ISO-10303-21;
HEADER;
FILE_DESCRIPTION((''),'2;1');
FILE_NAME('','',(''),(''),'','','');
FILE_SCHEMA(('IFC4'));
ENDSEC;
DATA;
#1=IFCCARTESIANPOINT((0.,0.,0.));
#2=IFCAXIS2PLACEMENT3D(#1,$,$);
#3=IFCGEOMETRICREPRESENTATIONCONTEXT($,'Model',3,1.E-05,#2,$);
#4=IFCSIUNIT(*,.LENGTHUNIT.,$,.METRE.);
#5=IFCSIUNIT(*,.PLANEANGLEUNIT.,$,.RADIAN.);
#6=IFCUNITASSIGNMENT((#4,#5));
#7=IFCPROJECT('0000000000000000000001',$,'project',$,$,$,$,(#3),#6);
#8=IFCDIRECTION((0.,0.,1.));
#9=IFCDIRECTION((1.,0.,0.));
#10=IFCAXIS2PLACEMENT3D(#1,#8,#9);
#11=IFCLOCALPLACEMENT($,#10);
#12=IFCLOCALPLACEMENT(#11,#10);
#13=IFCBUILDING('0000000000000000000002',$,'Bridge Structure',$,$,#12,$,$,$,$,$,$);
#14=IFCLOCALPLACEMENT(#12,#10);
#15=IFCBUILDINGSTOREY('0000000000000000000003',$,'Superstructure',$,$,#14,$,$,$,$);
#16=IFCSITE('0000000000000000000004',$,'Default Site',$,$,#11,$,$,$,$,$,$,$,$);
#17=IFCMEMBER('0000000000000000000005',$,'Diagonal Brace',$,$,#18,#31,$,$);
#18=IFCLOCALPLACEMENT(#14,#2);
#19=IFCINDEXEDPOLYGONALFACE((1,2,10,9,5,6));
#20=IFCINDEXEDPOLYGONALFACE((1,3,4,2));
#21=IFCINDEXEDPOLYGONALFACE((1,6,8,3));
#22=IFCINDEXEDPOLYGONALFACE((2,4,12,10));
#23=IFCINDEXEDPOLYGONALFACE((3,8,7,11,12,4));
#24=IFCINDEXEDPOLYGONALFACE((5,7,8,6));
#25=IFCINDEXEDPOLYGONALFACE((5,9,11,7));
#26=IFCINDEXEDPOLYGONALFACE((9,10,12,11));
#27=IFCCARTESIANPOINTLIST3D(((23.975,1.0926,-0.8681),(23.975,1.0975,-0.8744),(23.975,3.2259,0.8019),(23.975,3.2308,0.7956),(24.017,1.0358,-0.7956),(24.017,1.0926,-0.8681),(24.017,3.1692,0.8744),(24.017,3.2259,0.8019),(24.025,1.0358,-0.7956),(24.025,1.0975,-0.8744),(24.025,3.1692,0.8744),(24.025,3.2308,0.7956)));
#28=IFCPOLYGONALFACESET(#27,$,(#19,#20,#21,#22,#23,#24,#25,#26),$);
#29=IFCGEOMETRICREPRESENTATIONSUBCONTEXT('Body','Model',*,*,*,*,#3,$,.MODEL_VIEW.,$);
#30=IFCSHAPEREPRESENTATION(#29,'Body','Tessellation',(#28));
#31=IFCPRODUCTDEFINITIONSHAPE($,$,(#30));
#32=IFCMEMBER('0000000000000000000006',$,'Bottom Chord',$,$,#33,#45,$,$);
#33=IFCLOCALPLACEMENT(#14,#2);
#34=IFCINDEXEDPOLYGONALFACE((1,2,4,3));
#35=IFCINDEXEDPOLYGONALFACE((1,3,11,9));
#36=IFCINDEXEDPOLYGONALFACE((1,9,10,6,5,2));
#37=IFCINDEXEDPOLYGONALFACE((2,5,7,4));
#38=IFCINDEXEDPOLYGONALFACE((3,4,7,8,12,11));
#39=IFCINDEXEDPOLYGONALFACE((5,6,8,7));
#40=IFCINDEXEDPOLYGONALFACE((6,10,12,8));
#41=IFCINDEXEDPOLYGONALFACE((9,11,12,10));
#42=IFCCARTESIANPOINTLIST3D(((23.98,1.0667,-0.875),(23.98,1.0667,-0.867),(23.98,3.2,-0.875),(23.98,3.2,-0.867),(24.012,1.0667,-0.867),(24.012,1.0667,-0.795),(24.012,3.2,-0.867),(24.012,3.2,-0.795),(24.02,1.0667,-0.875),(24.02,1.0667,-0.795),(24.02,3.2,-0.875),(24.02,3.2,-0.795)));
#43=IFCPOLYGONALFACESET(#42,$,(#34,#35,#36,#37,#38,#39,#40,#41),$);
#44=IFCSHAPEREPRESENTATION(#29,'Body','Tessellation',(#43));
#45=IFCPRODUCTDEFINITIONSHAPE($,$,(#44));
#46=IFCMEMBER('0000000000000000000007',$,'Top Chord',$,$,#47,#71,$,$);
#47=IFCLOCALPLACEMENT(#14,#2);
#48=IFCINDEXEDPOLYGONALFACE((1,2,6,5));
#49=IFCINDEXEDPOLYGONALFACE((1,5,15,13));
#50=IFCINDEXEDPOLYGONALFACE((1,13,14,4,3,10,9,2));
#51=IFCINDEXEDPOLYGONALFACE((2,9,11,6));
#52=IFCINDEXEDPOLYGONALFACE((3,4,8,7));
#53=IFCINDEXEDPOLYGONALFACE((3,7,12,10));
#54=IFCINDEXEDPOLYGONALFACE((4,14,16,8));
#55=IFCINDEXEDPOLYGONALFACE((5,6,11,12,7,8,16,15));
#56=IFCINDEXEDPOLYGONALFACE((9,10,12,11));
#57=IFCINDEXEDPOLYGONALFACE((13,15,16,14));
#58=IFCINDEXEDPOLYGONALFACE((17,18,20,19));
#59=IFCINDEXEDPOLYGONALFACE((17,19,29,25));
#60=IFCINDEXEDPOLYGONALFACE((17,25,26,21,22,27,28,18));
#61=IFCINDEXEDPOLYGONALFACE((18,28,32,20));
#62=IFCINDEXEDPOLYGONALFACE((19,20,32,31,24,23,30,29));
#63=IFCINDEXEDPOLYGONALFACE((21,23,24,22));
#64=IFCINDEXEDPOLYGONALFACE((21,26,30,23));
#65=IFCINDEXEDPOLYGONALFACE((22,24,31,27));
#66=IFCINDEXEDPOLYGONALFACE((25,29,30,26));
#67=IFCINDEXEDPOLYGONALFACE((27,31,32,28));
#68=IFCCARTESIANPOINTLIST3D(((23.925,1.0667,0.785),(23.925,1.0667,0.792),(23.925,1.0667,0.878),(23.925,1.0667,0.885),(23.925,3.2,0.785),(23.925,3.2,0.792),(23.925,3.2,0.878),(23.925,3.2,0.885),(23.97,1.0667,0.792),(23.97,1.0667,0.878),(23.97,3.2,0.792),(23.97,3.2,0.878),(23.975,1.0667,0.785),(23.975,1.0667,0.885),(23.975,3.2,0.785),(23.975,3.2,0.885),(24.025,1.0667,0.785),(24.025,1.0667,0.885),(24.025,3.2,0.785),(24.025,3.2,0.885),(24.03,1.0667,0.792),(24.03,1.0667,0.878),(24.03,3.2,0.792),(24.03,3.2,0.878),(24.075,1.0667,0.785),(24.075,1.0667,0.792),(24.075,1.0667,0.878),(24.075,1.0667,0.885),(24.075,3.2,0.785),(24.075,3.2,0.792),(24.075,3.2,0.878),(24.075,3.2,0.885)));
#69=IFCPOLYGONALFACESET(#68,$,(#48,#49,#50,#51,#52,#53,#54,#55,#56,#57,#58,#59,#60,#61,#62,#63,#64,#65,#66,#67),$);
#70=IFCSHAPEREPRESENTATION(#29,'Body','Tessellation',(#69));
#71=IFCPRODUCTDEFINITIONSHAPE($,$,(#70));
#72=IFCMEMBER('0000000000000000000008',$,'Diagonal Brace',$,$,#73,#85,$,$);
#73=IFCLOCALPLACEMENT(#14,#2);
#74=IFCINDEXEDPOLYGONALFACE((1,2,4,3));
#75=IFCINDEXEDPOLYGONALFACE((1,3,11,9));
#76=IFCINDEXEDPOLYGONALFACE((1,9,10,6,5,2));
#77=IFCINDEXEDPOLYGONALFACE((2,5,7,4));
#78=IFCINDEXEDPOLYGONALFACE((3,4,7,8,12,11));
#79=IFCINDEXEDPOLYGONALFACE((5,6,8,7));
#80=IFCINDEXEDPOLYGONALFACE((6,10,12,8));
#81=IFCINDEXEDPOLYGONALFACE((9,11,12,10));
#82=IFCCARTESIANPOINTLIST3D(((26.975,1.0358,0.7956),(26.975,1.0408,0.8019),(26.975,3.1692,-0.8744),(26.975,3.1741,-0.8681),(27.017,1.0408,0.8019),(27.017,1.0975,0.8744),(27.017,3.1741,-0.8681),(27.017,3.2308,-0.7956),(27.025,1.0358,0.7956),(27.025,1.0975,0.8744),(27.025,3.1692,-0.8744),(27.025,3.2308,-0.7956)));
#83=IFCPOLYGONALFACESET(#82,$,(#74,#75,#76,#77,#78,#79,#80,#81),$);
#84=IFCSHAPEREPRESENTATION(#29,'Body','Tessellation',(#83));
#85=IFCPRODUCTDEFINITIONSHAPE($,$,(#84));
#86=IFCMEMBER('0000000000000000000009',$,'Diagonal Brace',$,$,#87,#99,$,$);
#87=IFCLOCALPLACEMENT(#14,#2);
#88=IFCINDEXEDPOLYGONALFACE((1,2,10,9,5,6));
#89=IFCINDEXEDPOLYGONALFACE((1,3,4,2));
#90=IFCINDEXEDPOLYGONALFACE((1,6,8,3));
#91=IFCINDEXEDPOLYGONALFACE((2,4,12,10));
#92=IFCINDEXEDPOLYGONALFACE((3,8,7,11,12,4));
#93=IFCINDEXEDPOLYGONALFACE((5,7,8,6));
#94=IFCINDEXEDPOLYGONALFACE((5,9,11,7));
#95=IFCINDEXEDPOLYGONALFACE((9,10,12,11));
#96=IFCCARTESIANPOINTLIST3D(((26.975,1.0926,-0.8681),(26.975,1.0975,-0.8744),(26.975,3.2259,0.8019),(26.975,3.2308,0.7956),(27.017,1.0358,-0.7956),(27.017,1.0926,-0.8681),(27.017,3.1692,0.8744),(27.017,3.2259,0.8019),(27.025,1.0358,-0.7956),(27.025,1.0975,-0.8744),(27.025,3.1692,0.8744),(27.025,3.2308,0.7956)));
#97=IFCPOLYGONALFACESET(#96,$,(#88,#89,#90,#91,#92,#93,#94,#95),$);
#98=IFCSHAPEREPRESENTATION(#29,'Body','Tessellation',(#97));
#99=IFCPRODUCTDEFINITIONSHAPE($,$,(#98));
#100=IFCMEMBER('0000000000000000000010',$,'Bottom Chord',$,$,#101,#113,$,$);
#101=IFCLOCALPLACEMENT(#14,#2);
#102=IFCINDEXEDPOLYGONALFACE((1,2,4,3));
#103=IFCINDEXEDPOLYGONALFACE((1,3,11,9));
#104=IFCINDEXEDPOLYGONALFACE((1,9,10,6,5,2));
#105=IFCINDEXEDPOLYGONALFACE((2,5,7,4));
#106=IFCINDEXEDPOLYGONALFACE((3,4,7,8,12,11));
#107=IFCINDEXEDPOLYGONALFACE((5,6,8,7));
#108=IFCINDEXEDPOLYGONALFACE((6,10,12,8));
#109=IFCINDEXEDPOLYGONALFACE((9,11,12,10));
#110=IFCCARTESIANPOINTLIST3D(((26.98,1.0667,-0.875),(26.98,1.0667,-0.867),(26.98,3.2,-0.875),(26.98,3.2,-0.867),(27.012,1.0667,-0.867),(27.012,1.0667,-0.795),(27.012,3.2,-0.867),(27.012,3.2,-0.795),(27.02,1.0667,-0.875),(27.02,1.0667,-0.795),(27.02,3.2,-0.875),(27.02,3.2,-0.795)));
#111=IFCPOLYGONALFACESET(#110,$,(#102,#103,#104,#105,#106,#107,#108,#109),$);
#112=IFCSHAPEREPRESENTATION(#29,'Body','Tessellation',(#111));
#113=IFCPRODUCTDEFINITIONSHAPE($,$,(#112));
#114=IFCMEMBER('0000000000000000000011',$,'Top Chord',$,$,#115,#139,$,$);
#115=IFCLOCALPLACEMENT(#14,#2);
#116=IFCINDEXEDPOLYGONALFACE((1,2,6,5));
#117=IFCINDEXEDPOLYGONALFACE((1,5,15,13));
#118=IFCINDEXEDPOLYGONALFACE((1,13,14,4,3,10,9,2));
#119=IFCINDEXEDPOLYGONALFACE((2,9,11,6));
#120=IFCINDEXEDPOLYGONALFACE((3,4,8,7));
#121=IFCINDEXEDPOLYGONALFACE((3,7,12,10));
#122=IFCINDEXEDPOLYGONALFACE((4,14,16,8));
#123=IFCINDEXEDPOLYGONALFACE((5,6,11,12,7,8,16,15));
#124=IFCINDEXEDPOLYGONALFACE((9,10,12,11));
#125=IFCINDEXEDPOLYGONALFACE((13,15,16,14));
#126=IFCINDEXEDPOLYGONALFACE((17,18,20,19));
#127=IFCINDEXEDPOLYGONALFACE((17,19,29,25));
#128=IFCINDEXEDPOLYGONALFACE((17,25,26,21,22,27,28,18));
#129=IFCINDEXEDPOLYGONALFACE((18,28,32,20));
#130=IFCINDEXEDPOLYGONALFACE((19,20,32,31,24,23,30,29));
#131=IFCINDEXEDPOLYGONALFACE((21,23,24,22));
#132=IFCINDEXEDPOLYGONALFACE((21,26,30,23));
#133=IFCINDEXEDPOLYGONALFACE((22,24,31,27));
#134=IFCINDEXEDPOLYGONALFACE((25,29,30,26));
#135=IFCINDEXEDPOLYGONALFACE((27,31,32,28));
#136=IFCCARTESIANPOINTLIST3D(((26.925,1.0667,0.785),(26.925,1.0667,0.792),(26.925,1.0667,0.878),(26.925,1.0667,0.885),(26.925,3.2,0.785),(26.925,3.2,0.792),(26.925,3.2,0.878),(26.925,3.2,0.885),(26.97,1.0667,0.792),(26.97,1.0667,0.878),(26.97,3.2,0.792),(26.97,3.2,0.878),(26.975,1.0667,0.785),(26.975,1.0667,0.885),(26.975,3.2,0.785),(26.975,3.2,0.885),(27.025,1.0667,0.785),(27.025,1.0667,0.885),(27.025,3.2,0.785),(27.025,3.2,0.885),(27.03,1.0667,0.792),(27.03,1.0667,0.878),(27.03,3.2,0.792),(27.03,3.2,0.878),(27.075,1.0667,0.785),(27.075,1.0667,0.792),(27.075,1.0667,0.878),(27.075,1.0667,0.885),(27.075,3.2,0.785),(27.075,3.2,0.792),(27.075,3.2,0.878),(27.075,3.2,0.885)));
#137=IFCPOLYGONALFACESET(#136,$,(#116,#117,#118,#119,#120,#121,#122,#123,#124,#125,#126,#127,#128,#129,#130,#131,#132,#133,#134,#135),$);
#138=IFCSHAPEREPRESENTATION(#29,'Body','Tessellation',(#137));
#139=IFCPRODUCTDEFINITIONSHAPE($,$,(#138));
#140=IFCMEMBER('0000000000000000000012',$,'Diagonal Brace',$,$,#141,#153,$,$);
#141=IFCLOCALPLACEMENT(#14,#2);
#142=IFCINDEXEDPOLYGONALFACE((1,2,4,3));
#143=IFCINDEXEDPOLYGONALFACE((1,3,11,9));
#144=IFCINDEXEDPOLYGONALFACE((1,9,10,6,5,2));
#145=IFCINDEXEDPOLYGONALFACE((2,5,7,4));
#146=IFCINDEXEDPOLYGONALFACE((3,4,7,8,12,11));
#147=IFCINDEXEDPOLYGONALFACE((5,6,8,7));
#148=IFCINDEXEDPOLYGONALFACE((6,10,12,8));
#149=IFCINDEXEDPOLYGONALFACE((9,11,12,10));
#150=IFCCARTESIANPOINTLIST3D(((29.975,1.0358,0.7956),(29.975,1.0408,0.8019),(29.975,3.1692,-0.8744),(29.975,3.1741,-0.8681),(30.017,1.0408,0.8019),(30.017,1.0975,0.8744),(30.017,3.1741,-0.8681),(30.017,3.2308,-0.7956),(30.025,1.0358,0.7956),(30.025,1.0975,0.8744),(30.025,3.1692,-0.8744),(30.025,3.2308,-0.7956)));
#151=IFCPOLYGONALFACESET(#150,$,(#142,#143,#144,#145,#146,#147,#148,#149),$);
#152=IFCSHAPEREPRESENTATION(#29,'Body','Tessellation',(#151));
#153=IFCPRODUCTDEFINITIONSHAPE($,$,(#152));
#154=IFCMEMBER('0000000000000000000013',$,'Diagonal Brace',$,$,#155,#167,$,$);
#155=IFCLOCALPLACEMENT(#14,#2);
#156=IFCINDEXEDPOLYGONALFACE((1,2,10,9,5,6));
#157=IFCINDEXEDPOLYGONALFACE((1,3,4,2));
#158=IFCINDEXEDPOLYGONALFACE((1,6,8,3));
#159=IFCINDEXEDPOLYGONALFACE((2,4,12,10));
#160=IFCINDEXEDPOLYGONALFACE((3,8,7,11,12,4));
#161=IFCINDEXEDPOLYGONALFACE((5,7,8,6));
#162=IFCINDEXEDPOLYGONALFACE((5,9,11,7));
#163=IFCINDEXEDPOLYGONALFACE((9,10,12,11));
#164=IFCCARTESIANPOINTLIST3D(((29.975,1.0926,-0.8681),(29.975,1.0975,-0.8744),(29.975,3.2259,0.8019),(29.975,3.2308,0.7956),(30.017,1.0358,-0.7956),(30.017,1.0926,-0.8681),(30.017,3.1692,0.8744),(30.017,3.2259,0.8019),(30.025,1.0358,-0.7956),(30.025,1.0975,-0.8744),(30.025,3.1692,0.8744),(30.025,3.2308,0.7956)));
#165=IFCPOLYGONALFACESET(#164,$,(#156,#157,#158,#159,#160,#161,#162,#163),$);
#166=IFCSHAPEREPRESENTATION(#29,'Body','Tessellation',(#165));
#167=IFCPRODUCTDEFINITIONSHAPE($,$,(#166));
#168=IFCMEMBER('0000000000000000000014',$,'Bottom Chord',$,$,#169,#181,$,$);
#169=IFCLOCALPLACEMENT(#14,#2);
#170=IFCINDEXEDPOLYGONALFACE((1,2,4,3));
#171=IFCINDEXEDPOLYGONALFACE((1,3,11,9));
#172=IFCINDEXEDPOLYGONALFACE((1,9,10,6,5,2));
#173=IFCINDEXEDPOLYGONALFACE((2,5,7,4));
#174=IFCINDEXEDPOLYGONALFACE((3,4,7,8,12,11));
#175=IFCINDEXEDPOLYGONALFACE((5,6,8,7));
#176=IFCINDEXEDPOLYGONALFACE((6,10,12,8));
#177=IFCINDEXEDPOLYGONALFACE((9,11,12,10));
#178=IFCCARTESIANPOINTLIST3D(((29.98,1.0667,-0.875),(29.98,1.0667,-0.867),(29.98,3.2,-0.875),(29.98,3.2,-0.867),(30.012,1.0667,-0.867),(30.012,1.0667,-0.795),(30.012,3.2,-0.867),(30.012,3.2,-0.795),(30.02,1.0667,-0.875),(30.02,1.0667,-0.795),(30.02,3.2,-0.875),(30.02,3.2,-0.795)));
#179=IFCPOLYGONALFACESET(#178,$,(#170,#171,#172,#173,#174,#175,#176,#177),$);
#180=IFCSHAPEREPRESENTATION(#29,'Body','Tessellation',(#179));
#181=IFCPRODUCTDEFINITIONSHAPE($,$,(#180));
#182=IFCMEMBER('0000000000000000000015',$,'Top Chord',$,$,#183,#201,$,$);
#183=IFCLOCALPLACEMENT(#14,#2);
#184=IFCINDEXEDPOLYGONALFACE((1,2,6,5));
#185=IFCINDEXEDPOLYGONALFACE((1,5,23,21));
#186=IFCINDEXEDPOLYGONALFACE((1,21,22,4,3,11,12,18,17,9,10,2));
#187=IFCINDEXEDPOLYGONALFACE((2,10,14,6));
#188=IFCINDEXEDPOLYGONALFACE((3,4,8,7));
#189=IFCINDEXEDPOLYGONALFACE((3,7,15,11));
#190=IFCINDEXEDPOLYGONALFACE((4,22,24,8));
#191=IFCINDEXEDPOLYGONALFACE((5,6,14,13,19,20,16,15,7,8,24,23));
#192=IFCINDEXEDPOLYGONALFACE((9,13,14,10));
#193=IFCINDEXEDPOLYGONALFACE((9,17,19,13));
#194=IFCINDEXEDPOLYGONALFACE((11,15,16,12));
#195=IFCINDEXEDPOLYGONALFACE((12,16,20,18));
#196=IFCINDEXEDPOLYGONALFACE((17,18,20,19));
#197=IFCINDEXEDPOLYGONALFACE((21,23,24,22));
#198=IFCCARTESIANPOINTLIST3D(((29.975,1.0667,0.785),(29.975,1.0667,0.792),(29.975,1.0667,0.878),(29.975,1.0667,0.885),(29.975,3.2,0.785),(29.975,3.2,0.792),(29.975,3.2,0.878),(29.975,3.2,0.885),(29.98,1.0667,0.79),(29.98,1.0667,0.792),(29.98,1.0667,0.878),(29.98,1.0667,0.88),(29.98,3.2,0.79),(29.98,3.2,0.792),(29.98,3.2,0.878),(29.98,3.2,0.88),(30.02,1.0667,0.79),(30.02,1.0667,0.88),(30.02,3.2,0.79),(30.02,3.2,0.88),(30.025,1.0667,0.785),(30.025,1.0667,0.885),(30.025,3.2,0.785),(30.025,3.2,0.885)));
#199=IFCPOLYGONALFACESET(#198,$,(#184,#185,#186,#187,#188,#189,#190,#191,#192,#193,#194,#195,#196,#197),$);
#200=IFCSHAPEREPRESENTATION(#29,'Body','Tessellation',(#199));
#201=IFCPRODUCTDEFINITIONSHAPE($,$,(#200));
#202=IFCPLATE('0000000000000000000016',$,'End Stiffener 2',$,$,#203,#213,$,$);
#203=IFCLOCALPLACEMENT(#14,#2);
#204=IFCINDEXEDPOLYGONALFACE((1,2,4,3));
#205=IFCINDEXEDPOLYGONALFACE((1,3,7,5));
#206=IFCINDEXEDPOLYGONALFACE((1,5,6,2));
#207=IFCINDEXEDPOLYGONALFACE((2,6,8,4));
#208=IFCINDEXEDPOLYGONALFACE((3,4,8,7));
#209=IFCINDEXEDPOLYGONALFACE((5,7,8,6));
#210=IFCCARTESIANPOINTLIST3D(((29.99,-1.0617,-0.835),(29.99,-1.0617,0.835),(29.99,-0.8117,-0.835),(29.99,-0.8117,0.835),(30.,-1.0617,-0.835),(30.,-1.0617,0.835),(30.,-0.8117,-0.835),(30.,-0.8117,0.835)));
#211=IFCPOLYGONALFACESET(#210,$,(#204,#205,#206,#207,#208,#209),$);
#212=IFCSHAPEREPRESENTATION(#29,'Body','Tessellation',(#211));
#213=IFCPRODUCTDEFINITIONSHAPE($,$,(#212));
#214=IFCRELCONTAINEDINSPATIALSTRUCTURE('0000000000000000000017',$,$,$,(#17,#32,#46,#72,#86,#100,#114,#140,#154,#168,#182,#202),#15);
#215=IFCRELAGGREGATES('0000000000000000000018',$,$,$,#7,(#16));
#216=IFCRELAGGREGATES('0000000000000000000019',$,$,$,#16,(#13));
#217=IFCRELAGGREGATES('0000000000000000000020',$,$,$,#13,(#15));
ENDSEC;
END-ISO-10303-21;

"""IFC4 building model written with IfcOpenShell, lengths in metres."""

from ifc_helpers import new_model, si_unit, frame, origin, origin_with_axes, origin_2d_with_axis, place, context, subcontext, project, spatial, polyline, rectangle, l_section, c_section, outline, composite_profile, extrude, element, save


model = new_model("IFC4")

# Units and contexts
model_context = context("Model", 3, precision=1e-05, world=origin())
body_context = subcontext(model_context, "Body", "Model", "MODEL_VIEW")
ifc_project = project(units=[si_unit("LENGTHUNIT", "METRE"), si_unit("PLANEANGLEUNIT", "RADIAN")], contexts=[model_context])

# Site, building, storey
site_placement = place(None, origin_with_axes())
site = spatial("IfcSite", under=ifc_project, at=site_placement, Name="Default Site")
building_placement = place(site_placement, origin_with_axes())
building = spatial("IfcBuilding", under=site, at=building_placement, Name="Bridge Structure")
storey_placement = place(building_placement, origin_with_axes())
storey = spatial("IfcBuildingStorey", under=building, at=storey_placement, Name="Superstructure")

# Members
member_1_placement = place(storey_placement, frame((24.0, 1.0667, -0.835), z_axis=(0.0, 0.787427, 0.616408), x_axis=(-1.0, 0.0, 0.0)))
element("IfcMember", 1, at=member_1_placement, inside=storey, Name="Diagonal Brace", context=body_context, shape_type="SweptSolid", body=[
    extrude(l_section(Depth=0.1, Width=0.05, Thickness=0.008, at=origin_2d_with_axis()), origin_with_axes(), (0.0, 0.0, 1.0), 2.7092),
])
member_2_placement = place(storey_placement, frame((24.0, 1.0667, -0.835), z_axis=(0.0, 1.0, 0.0), x_axis=(-1.0, 0.0, 0.0)))
element("IfcMember", 2, at=member_2_placement, inside=storey, Name="Bottom Chord", context=body_context, shape_type="SweptSolid", body=[
    extrude(l_section(Depth=0.08, Width=0.04, Thickness=0.008, at=origin_2d_with_axis()), origin_with_axes(), (0.0, 0.0, 1.0), 2.1333),
])
member_3_placement = place(storey_placement, frame((24.0, 1.0667, 0.835), z_axis=(0.0, 1.0, 0.0), x_axis=(-1.0, 0.0, 0.0)))
element("IfcMember", 3, at=member_3_placement, inside=storey, Name="Top Chord", context=body_context, shape_type="SweptSolid", body=[
    extrude(composite_profile([outline(polyline([(-0.025, -0.05), (-0.025, 0.05), (-0.075, 0.05), (-0.075, 0.043), (-0.03, 0.043), (-0.03, -0.043), (-0.075, -0.043), (-0.075, -0.05), (-0.025, -0.05)])), outline(polyline([(0.025, -0.05), (0.075, -0.05), (0.075, -0.043), (0.03, -0.043), (0.03, 0.043), (0.075, 0.043), (0.075, 0.05), (0.025, 0.05), (0.025, -0.05)]))]), origin_with_axes(), (0.0, 0.0, 1.0), 2.1333),
])
for number, where, z_axis, x_axis, name in (
    (4, (27.0, 1.0667, 0.835), (0.0, 0.787427, -0.616408), (-1.0, 0.0, 0.0), "Diagonal Brace"),
    (5, (27.0, 1.0667, -0.835), (0.0, 0.787427, 0.616408), (-1.0, 0.0, 0.0), "Diagonal Brace"),
):
    element("IfcMember", number, at=place(storey_placement, frame(where, z_axis=z_axis, x_axis=x_axis)), inside=storey, Name=name, context=body_context, shape_type="SweptSolid", body=[
        extrude(l_section(Depth=0.1, Width=0.05, Thickness=0.008, at=origin_2d_with_axis()), origin_with_axes(), (0.0, 0.0, 1.0), 2.7092),
    ])
member_4_placement = place(storey_placement, frame((27.0, 1.0667, -0.835), z_axis=(0.0, 1.0, 0.0), x_axis=(-1.0, 0.0, 0.0)))
element("IfcMember", 6, at=member_4_placement, inside=storey, Name="Bottom Chord", context=body_context, shape_type="SweptSolid", body=[
    extrude(l_section(Depth=0.08, Width=0.04, Thickness=0.008, at=origin_2d_with_axis()), origin_with_axes(), (0.0, 0.0, 1.0), 2.1333),
])
member_5_placement = place(storey_placement, frame((27.0, 1.0667, 0.835), z_axis=(0.0, 1.0, 0.0), x_axis=(-1.0, 0.0, 0.0)))
element("IfcMember", 7, at=member_5_placement, inside=storey, Name="Top Chord", context=body_context, shape_type="SweptSolid", body=[
    extrude(composite_profile([outline(polyline([(-0.025, -0.05), (-0.025, 0.05), (-0.075, 0.05), (-0.075, 0.043), (-0.03, 0.043), (-0.03, -0.043), (-0.075, -0.043), (-0.075, -0.05), (-0.025, -0.05)])), outline(polyline([(0.025, -0.05), (0.075, -0.05), (0.075, -0.043), (0.03, -0.043), (0.03, 0.043), (0.075, 0.043), (0.075, 0.05), (0.025, 0.05), (0.025, -0.05)]))]), origin_with_axes(), (0.0, 0.0, 1.0), 2.1333),
])
for number, where, z_axis, x_axis, name in (
    (8, (30.0, 1.0667, 0.835), (0.0, 0.787427, -0.616408), (-1.0, 0.0, 0.0), "Diagonal Brace"),
    (9, (30.0, 1.0667, -0.835), (0.0, 0.787427, 0.616408), (-1.0, 0.0, 0.0), "Diagonal Brace"),
):
    element("IfcMember", number, at=place(storey_placement, frame(where, z_axis=z_axis, x_axis=x_axis)), inside=storey, Name=name, context=body_context, shape_type="SweptSolid", body=[
        extrude(l_section(Depth=0.1, Width=0.05, Thickness=0.008, at=origin_2d_with_axis()), origin_with_axes(), (0.0, 0.0, 1.0), 2.7092),
    ])
member_6_placement = place(storey_placement, frame((30.0, 1.0667, -0.835), z_axis=(0.0, 1.0, 0.0), x_axis=(-1.0, 0.0, 0.0)))
element("IfcMember", 10, at=member_6_placement, inside=storey, Name="Bottom Chord", context=body_context, shape_type="SweptSolid", body=[
    extrude(l_section(Depth=0.08, Width=0.04, Thickness=0.008, at=origin_2d_with_axis()), origin_with_axes(), (0.0, 0.0, 1.0), 2.1333),
])
member_7_placement = place(storey_placement, frame((30.0, 1.0667, 0.835), z_axis=(0.0, 1.0, 0.0), x_axis=(-1.0, 0.0, 0.0)))
element("IfcMember", 11, at=member_7_placement, inside=storey, Name="Top Chord", context=body_context, shape_type="SweptSolid", body=[
    extrude(c_section(Depth=0.1, Width=0.05, WallThickness=0.005, Girth=0.007, at=origin_2d_with_axis()), origin_with_axes(), (0.0, 0.0, 1.0), 2.1333),
])

# Plate
for number, where, z_axis, x_axis, name in (
    (12, (29.995, -0.9367, -0.835), (0.0, 0.0, 1.0), (1.0, 0.0, 0.0), "End Stiffener 2"),
):
    element("IfcPlate", number, at=place(storey_placement, frame(where, z_axis=z_axis, x_axis=x_axis)), inside=storey, Name=name, context=body_context, shape_type="SweptSolid", body=[
        extrude(rectangle(XDim=0.01, YDim=0.25, at=origin_2d_with_axis()), origin_with_axes(), (0.0, 0.0, 1.0), 1.67),
    ])

save(model, "model.ifc")
